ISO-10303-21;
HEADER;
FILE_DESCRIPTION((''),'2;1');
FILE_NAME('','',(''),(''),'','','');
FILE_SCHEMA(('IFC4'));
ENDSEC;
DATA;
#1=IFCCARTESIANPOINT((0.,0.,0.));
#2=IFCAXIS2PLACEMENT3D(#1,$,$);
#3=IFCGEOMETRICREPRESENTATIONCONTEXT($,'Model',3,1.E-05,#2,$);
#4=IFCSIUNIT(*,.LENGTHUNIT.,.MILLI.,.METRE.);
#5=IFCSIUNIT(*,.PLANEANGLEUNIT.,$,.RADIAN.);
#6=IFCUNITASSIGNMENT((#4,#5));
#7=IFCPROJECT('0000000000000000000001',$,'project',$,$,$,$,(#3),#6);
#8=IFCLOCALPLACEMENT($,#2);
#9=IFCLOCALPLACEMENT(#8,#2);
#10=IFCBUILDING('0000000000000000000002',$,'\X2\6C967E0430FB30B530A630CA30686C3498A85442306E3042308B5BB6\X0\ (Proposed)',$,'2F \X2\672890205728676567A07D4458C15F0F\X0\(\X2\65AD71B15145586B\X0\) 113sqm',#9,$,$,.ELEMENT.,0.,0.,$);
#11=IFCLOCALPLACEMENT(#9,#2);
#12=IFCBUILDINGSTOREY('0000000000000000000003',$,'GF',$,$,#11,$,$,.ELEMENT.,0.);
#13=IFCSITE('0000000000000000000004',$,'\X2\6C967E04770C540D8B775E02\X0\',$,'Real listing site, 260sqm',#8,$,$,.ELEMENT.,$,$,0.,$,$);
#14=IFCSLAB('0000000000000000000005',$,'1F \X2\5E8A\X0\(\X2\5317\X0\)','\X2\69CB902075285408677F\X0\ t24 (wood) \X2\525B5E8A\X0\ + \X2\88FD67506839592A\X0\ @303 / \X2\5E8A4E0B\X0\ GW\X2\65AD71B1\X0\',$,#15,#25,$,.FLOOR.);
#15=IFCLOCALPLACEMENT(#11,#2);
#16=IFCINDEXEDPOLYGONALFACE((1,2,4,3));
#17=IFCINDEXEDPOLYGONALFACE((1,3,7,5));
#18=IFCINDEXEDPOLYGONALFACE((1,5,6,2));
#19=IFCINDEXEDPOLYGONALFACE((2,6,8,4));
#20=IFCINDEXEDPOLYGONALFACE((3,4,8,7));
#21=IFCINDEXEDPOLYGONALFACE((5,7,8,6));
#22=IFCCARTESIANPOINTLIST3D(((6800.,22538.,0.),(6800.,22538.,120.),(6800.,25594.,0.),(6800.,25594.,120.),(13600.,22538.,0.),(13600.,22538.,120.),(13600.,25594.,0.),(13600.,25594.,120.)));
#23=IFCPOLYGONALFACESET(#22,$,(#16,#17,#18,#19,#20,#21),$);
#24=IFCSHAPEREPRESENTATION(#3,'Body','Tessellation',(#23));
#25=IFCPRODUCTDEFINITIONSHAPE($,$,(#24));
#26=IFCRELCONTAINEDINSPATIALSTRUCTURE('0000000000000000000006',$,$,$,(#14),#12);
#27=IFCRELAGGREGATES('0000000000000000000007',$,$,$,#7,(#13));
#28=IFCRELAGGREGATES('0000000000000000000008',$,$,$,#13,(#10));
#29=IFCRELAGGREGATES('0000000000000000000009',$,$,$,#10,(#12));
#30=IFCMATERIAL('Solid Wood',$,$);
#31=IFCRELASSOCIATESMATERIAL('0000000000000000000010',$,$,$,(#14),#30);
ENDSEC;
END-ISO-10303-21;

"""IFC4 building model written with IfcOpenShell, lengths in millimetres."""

from ifc_helpers import new_model, si_unit, frame, frame_2d, origin, place, context, project, spatial, rectangle, extrude, material, element, save


model = new_model("IFC4")

# Units and contexts
model_context = context("Model", 3, precision=1e-05, world=origin())
ifc_project = project(units=[si_unit("LENGTHUNIT", "METRE", prefix="MILLI"), si_unit("PLANEANGLEUNIT", "RADIAN")], contexts=[model_context])

# Site, building, storey
site_placement = place(None, origin())
site = spatial("IfcSite", under=ifc_project, at=site_placement, Name="沖縄県名護市", ObjectType="Real listing site, 260sqm", CompositionType="ELEMENT", RefElevation=0.0)
building_placement = place(site_placement, origin())
building = spatial("IfcBuilding", under=site, at=building_placement, Name="沖縄・サウナと水風呂のある家 (Proposed)", ObjectType="2F 木造在来枠組壁式(断熱充填) 113sqm", CompositionType="ELEMENT", ElevationOfRefHeight=0.0, ElevationOfTerrain=0.0)
storey_placement = place(building_placement, origin())
storey = spatial("IfcBuildingStorey", under=building, at=storey_placement, Name="GF", CompositionType="ELEMENT", Elevation=0.0)

# Shared definitions
ifc_material_1 = material(Name="Solid Wood")

# Slab
slab_1_placement = place(storey_placement, frame((3400.0, 11269.0, 0.0)))
element("IfcSlab", 1, at=slab_1_placement, inside=storey, material=ifc_material_1, Name="1F 床(北)", Description="構造用合板 t24 (wood) 剛床 + 製材根太 @303 / 床下 GW断熱", PredefinedType="FLOOR", context=model_context, shape_type="SweptSolid", body=[
    extrude(rectangle(XDim=6800.0, YDim=3056.0, at=frame_2d((3400.0, 1528.0))), frame((3400.0, 11269.0, 0.0)), (0.0, 0.0, 1.0), 120.0),
])

save(model, "model.ifc")
